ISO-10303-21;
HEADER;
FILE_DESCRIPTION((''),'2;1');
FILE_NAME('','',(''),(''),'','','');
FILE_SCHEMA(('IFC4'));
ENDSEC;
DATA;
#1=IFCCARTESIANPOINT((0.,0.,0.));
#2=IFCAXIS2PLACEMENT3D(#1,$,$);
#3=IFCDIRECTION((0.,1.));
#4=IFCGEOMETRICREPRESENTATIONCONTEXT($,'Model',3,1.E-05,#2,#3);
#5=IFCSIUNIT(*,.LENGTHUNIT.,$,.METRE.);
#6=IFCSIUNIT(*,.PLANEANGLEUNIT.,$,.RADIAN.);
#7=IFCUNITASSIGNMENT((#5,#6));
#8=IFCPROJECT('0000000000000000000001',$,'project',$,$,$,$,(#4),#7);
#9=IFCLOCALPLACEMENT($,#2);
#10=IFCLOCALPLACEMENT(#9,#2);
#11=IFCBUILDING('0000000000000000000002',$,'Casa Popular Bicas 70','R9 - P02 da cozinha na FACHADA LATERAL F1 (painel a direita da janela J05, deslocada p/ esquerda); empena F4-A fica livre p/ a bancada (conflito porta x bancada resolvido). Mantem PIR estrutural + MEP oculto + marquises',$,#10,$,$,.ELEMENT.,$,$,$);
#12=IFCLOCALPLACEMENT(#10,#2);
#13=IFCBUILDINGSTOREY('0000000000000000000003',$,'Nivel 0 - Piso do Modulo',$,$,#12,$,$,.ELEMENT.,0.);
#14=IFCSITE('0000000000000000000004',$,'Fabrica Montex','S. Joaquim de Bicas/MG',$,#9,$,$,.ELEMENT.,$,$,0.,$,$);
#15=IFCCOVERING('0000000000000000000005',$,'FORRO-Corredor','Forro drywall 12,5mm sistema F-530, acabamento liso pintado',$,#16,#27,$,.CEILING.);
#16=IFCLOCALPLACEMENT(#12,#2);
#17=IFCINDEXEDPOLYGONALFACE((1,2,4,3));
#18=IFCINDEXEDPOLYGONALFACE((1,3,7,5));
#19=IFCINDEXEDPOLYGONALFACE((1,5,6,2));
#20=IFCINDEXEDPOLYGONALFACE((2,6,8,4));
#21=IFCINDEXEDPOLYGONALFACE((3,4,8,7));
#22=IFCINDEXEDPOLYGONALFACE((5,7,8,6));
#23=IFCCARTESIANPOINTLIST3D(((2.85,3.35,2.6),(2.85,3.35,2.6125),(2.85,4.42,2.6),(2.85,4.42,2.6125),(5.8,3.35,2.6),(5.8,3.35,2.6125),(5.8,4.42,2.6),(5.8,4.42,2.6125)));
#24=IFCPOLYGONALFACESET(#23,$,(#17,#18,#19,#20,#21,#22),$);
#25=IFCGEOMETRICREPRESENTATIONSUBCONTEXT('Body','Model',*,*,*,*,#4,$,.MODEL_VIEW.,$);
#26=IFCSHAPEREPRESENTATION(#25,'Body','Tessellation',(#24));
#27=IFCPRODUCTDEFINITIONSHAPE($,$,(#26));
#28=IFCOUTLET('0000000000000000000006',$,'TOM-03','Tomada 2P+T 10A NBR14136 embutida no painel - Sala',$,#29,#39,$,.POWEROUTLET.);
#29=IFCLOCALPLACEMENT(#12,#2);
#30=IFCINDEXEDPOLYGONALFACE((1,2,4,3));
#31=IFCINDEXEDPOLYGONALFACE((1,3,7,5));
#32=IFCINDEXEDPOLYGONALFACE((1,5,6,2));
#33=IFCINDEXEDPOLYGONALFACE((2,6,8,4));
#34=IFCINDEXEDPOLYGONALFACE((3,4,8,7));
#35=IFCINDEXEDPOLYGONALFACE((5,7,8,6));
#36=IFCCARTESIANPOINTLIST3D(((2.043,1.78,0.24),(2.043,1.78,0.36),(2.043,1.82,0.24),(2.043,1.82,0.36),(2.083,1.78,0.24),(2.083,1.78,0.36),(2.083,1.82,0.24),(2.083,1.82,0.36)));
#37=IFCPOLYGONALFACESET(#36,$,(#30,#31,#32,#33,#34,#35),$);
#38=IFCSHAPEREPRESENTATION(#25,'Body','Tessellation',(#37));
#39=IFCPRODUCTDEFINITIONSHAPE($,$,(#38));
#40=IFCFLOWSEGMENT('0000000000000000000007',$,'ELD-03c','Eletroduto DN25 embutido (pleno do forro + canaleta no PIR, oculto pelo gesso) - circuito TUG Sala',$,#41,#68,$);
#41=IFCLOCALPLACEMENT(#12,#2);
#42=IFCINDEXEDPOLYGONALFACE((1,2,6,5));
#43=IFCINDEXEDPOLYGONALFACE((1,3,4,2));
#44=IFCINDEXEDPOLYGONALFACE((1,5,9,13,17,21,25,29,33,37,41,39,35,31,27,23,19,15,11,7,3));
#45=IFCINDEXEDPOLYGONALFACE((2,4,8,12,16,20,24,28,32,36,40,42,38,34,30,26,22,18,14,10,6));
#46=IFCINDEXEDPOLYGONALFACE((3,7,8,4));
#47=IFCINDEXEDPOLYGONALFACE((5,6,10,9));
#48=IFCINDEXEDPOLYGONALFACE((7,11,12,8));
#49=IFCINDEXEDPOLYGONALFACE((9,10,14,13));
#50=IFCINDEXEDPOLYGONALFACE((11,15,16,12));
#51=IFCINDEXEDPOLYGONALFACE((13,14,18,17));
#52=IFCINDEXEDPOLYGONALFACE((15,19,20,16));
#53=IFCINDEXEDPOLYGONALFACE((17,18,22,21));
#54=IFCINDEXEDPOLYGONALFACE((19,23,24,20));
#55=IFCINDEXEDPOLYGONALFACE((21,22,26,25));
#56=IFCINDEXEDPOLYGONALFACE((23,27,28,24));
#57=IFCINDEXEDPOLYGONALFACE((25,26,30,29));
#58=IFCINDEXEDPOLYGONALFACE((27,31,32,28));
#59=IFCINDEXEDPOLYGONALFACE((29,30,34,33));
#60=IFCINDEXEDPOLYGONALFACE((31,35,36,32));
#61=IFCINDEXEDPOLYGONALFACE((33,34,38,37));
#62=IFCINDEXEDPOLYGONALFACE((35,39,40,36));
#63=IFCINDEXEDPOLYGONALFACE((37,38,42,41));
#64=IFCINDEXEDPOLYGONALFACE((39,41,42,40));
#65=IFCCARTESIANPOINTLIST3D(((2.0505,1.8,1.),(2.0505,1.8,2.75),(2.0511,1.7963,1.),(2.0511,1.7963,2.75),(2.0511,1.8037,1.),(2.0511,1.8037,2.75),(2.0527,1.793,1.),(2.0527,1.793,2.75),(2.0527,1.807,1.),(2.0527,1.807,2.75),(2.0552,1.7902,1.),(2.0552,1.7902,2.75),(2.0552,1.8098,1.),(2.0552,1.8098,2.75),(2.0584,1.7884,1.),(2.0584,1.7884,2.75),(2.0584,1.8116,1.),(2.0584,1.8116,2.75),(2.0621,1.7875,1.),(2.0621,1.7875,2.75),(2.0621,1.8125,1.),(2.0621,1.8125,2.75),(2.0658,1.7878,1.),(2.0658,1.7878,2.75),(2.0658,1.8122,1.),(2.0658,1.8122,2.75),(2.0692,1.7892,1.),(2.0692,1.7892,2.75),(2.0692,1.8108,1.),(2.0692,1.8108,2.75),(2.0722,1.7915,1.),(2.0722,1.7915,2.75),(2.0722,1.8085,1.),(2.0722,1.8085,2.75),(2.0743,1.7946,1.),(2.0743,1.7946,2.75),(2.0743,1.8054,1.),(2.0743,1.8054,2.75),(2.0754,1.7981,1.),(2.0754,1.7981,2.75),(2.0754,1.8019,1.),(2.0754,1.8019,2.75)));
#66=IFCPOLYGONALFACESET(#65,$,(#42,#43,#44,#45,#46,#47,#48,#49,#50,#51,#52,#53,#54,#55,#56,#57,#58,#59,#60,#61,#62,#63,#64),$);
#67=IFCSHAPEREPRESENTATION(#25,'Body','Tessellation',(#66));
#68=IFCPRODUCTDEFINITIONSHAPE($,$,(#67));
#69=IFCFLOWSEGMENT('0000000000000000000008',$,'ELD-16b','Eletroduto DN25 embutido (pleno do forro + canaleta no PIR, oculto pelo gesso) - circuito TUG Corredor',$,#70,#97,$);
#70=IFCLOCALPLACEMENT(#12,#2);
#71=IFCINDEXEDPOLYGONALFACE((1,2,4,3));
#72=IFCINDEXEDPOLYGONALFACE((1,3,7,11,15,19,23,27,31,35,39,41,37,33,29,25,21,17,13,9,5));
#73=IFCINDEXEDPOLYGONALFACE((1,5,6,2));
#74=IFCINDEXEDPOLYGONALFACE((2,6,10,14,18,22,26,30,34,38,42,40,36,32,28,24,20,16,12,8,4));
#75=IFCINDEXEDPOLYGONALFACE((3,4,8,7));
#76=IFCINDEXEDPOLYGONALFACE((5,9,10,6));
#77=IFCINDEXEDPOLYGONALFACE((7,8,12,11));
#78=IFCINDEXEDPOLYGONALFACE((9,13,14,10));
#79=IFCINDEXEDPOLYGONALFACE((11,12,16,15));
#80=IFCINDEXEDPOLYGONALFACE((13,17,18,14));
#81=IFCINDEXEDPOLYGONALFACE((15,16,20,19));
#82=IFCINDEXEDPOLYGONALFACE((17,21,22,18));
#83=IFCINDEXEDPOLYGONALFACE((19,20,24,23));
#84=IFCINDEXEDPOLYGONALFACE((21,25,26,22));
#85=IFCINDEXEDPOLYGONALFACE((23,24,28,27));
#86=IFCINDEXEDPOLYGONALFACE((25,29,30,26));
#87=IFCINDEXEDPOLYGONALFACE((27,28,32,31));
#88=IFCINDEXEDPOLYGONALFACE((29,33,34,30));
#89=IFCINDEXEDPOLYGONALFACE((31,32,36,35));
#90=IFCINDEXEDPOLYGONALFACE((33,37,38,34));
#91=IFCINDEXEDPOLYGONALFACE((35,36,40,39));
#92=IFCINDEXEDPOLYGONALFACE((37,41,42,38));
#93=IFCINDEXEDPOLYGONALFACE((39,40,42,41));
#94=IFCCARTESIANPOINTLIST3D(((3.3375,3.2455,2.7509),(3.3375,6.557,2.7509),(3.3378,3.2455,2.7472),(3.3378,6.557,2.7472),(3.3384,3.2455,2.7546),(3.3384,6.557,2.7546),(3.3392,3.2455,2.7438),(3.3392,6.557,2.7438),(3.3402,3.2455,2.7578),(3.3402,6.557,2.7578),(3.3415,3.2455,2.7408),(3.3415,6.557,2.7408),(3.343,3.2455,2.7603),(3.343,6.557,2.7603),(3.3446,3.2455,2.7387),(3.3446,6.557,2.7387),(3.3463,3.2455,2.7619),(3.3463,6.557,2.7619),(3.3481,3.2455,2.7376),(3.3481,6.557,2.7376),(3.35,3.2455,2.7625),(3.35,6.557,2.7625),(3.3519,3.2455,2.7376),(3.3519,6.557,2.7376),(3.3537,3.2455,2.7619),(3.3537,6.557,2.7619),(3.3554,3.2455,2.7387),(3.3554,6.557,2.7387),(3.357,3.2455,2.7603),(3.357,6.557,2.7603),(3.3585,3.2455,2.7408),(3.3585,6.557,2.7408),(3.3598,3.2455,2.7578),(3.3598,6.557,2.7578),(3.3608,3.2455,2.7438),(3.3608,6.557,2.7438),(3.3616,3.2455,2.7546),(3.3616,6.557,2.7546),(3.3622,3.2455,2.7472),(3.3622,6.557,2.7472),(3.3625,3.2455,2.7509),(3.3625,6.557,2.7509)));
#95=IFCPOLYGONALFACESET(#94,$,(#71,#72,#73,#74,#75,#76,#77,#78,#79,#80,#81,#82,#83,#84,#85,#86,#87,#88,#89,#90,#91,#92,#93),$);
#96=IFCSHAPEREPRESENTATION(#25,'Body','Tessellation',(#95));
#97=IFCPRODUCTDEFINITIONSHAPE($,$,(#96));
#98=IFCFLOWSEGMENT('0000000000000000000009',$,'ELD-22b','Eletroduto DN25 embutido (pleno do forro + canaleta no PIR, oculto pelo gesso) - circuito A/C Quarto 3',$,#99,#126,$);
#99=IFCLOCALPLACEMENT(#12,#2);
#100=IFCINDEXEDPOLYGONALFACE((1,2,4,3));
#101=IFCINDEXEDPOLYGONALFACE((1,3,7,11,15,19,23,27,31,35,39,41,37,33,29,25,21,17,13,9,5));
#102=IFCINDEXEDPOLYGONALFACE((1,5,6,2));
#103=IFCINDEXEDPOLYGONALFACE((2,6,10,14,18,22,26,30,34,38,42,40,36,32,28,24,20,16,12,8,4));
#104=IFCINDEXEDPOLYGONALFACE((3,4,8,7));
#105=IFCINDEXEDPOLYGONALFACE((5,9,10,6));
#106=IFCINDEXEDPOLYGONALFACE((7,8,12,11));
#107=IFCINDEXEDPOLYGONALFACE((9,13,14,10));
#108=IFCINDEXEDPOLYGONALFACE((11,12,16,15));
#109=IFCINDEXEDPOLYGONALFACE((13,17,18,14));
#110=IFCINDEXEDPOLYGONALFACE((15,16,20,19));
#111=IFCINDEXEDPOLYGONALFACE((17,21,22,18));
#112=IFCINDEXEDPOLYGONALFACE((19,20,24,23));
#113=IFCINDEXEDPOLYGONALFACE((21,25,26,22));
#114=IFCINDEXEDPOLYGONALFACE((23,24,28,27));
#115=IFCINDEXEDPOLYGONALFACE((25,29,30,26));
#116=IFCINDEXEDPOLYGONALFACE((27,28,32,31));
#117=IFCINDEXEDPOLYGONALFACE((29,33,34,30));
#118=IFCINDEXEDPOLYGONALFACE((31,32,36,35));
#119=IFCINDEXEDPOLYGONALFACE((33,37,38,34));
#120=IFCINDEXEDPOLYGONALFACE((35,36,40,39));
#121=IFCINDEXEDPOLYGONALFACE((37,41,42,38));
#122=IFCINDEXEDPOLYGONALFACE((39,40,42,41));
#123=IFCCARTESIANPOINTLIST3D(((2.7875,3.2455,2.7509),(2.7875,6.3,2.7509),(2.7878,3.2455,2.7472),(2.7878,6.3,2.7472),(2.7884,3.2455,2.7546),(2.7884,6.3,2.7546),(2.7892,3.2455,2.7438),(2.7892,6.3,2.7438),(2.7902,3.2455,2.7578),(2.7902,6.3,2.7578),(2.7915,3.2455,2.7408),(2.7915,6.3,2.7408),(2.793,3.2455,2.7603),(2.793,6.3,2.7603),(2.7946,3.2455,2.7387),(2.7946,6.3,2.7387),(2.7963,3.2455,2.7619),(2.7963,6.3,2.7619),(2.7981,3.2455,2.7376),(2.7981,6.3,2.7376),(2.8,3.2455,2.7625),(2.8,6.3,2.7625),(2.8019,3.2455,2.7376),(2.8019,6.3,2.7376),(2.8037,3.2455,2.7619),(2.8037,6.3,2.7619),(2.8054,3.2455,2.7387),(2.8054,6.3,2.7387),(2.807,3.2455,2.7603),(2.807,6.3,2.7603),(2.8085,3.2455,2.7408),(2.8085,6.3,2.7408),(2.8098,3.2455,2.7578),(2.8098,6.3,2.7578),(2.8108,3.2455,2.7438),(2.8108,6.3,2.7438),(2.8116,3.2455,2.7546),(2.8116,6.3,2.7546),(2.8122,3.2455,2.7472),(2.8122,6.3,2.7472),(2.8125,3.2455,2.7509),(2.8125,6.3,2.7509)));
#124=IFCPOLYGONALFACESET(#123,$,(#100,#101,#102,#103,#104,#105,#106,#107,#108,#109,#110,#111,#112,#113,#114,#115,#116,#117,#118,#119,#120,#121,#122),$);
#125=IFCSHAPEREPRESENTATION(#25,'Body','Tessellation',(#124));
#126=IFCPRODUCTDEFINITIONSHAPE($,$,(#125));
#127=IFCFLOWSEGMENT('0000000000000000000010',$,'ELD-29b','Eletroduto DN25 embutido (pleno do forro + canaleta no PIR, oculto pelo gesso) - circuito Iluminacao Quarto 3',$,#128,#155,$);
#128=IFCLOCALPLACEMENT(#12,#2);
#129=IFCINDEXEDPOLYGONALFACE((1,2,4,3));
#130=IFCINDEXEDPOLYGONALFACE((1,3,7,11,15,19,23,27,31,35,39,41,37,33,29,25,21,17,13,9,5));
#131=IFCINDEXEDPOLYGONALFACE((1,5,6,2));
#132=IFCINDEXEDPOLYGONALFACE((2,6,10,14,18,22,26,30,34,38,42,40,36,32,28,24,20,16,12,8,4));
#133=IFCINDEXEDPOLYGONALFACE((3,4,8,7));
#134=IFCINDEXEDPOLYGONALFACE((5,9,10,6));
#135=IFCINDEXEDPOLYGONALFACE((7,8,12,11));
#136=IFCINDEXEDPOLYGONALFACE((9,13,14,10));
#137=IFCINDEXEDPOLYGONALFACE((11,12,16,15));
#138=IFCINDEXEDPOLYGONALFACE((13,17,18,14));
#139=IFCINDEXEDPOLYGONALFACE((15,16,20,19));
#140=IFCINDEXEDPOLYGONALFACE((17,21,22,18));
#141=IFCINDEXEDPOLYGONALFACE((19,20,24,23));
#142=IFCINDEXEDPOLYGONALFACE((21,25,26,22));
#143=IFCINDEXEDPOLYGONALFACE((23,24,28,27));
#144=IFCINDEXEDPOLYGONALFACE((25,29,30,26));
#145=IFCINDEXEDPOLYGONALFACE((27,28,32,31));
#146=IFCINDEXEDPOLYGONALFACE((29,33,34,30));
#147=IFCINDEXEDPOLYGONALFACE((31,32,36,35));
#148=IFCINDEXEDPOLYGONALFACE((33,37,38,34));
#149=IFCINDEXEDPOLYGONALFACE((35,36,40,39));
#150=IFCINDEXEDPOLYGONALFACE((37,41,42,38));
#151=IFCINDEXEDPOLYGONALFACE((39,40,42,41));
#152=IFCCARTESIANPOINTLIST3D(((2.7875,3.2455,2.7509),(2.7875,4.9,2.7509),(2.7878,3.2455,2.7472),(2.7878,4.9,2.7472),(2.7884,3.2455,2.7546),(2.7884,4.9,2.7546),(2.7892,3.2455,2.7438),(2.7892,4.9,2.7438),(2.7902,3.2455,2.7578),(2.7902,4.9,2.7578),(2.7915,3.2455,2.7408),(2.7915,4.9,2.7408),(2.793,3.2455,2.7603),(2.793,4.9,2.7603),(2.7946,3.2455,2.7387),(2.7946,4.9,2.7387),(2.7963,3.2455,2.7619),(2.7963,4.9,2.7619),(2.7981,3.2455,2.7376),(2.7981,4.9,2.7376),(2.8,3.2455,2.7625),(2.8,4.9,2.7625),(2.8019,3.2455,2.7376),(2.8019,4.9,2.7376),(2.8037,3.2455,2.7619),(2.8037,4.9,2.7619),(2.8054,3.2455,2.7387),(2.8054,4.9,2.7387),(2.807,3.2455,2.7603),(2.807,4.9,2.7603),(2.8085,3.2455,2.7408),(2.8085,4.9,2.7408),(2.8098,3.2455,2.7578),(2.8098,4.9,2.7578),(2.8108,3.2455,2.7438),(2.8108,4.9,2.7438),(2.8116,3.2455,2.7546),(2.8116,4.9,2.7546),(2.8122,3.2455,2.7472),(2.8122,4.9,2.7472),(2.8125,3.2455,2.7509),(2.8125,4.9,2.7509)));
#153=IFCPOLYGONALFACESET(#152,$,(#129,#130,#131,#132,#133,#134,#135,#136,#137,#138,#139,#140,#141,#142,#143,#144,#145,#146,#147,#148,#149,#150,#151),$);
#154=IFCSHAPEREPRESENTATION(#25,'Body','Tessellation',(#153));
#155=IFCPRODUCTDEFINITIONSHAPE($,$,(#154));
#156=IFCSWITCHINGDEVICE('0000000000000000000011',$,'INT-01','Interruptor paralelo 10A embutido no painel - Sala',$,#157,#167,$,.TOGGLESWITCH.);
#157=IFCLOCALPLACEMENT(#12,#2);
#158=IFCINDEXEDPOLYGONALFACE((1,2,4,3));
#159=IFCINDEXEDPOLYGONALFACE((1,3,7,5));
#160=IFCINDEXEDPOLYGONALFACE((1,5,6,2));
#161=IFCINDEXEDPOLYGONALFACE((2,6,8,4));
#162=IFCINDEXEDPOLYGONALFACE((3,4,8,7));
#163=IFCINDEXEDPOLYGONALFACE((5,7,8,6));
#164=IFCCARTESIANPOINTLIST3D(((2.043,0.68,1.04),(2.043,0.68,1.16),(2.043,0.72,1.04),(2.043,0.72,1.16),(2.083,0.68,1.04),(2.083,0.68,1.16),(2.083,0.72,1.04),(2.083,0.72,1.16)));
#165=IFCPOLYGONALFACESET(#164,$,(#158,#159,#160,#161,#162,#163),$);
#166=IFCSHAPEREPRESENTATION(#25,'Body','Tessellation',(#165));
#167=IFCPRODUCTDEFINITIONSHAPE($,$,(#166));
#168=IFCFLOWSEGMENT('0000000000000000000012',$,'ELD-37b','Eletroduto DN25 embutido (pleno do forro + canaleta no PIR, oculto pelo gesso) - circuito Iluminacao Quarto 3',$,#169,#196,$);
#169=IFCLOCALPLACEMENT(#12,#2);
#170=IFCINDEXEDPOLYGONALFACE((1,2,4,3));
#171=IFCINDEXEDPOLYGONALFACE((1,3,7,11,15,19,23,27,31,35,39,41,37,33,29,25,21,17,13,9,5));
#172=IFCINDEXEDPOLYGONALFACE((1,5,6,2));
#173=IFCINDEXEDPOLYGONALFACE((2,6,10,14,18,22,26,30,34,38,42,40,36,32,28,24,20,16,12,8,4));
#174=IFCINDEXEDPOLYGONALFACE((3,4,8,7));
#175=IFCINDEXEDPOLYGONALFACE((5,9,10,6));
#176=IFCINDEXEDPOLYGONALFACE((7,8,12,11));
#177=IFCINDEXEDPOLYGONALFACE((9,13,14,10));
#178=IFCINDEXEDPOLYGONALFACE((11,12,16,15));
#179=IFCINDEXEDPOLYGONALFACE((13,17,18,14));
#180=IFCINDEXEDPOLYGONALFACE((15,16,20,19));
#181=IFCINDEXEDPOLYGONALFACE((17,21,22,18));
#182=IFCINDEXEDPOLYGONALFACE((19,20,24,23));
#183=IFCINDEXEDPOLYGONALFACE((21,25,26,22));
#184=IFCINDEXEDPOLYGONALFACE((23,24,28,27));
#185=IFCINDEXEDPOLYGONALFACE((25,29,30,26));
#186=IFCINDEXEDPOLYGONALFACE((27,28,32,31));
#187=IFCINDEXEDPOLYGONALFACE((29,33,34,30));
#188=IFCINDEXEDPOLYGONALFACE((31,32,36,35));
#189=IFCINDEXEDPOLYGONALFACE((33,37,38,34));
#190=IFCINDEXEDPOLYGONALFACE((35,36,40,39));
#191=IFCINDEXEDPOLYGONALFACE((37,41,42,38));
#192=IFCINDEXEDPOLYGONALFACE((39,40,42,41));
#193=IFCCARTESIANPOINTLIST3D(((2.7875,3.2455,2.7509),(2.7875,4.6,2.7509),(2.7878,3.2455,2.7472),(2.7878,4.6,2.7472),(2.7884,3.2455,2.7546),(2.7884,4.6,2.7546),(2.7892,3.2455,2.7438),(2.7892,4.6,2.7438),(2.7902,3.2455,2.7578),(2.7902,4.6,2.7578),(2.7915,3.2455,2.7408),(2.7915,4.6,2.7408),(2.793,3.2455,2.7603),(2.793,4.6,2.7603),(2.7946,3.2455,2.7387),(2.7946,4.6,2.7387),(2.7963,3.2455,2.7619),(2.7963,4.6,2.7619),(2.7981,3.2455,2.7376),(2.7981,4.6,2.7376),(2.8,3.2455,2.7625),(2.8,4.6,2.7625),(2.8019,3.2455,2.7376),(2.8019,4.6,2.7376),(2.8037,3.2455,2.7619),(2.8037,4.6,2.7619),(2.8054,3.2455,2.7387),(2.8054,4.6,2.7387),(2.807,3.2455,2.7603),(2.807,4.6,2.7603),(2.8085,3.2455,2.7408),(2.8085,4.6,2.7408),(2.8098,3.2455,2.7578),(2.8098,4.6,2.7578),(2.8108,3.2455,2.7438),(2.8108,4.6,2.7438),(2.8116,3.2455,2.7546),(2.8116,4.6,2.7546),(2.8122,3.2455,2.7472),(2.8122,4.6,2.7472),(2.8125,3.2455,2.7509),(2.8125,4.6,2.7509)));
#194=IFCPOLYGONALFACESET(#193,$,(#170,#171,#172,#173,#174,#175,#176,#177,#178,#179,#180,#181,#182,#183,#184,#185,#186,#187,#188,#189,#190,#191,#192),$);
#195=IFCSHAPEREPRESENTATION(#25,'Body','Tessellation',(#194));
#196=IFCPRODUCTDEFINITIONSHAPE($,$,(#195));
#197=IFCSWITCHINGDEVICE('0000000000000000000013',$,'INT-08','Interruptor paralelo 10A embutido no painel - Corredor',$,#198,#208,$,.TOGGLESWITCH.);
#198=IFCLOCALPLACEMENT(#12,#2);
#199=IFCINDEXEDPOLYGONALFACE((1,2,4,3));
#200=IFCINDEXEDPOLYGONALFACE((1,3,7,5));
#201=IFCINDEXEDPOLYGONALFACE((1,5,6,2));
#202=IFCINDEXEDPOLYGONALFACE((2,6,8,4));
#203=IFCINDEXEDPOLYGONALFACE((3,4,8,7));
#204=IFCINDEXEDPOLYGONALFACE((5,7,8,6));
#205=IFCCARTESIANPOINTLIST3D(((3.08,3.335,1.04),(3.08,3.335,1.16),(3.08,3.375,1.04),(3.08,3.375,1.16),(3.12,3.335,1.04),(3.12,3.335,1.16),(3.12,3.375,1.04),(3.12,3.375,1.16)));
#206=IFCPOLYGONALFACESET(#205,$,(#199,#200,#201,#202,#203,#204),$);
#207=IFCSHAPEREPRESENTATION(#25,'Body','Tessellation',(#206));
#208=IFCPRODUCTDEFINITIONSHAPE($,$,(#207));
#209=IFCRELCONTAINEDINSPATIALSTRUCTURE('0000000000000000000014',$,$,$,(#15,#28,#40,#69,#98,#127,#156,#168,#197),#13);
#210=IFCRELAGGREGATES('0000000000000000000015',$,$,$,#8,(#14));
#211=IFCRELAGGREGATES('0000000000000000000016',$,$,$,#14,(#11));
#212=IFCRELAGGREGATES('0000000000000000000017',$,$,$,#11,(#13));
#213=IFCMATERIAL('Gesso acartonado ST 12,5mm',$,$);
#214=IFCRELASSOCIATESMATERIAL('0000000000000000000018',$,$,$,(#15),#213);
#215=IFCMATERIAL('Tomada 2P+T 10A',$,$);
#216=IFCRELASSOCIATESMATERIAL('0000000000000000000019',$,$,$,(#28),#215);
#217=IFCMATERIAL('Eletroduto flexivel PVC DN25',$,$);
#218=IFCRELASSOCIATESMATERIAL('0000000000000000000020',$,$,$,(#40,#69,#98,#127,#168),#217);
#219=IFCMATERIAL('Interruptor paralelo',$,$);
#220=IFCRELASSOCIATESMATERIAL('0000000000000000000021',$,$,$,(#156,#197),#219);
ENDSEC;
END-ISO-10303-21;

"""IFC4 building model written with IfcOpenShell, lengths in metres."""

from ifc_helpers import new_model, si_unit, direction, frame, frame_2d, origin, origin_2d, place, context, subcontext, project, spatial, rectangle, circle, extrude, material, element, save


model = new_model("IFC4")

# Units and contexts
model_context = context("Model", 3, precision=1e-05, world=origin(), true_north=direction((0.0, 1.0)))
body_context = subcontext(model_context, "Body", "Model", "MODEL_VIEW")
ifc_project = project(units=[si_unit("LENGTHUNIT", "METRE"), si_unit("PLANEANGLEUNIT", "RADIAN")], contexts=[model_context])

# Site, building, storey
site_placement = place(None, origin())
site = spatial("IfcSite", under=ifc_project, at=site_placement, Name="Fabrica Montex", Description="S. Joaquim de Bicas/MG", CompositionType="ELEMENT", RefElevation=0.0)
building_placement = place(site_placement, origin())
building = spatial("IfcBuilding", under=site, at=building_placement, Name="Casa Popular Bicas 70", Description="R9 - P02 da cozinha na FACHADA LATERAL F1 (painel a direita da janela J05, deslocada p/ esquerda); empena F4-A fica livre p/ a bancada (conflito porta x bancada resolvido). Mantem PIR estrutural + MEP oculto + marquises", CompositionType="ELEMENT")
storey_placement = place(building_placement, origin())
storey = spatial("IfcBuildingStorey", under=building, at=storey_placement, Name="Nivel 0 - Piso do Modulo", CompositionType="ELEMENT", Elevation=0.0)

# Covering
ifc_material_1 = material(Name="Gesso acartonado ST 12,5mm")
covering_1_placement = place(storey_placement, frame((2.85, 3.35, 2.6)))
element("IfcCovering", 1, at=covering_1_placement, inside=storey, material=ifc_material_1, Name="FORRO-Corredor", Description="Forro drywall 12,5mm sistema F-530, acabamento liso pintado", PredefinedType="CEILING", context=body_context, shape_type="SweptSolid", body=[
    extrude(rectangle(XDim=2.95, YDim=1.07, at=frame_2d((1.475, 0.535))), origin(), (0.0, 0.0, 1.0), 0.0125),
])

# Outlet
ifc_material_2 = material(Name="Tomada 2P+T 10A")
outlet_placement = place(None, frame((2.083, 1.82, 0.24), z_axis=(0.0, 0.0, 1.0), x_axis=(-1.0, 0.0, 0.0)))
element("IfcOutlet", 2, at=outlet_placement, inside=storey, material=ifc_material_2, Name="TOM-03", Description="Tomada 2P+T 10A NBR14136 embutida no painel - Sala", PredefinedType="POWEROUTLET", context=body_context, shape_type="SweptSolid", body=[
    extrude(rectangle(XDim=0.04, YDim=0.04, at=frame_2d((0.02, 0.02))), origin(), (0.0, 0.0, 1.0), 0.12),
])

# Flow segments
ifc_material_3 = material(Name="Eletroduto flexivel PVC DN25")
flow_segment_1_placement = place(None, frame((2.063, 1.8, 2.75), z_axis=(0.0, 0.0, -1.0), x_axis=(-1.0, 0.0, 0.0)))
element("IfcFlowSegment", 3, at=flow_segment_1_placement, inside=storey, material=ifc_material_3, Name="ELD-03c", Description="Eletroduto DN25 embutido (pleno do forro + canaleta no PIR, oculto pelo gesso) - circuito TUG Sala", context=body_context, shape_type="SweptSolid", body=[
    extrude(circle(Radius=0.0125, at=origin_2d()), origin(), (0.0, 0.0, 1.0), 1.75),
])
flow_segment_2_placement = place(storey_placement, frame((3.35, 3.2455, 2.75), z_axis=(0.0, 1.0, 0.0), x_axis=(0.0, 0.0, 1.0)))
element("IfcFlowSegment", 4, at=flow_segment_2_placement, inside=storey, material=ifc_material_3, Name="ELD-16b", Description="Eletroduto DN25 embutido (pleno do forro + canaleta no PIR, oculto pelo gesso) - circuito TUG Corredor", context=body_context, shape_type="SweptSolid", body=[
    extrude(circle(Radius=0.0125, at=origin_2d()), origin(), (0.0, 0.0, 1.0), 3.3115),
])
flow_segment_3_placement = place(storey_placement, frame((2.8, 3.2455, 2.75), z_axis=(0.0, 1.0, 0.0), x_axis=(0.0, 0.0, 1.0)))
element("IfcFlowSegment", 5, at=flow_segment_3_placement, inside=storey, material=ifc_material_3, Name="ELD-22b", Description="Eletroduto DN25 embutido (pleno do forro + canaleta no PIR, oculto pelo gesso) - circuito A/C Quarto 3", context=body_context, shape_type="SweptSolid", body=[
    extrude(circle(Radius=0.0125, at=origin_2d()), origin(), (0.0, 0.0, 1.0), 3.0545),
])
flow_segment_4_placement = place(storey_placement, frame((2.8, 3.2455, 2.75), z_axis=(0.0, 1.0, 0.0), x_axis=(0.0, 0.0, 1.0)))
element("IfcFlowSegment", 6, at=flow_segment_4_placement, inside=storey, material=ifc_material_3, Name="ELD-29b", Description="Eletroduto DN25 embutido (pleno do forro + canaleta no PIR, oculto pelo gesso) - circuito Iluminacao Quarto 3", context=body_context, shape_type="SweptSolid", body=[
    extrude(circle(Radius=0.0125, at=origin_2d()), origin(), (0.0, 0.0, 1.0), 1.6545),
])

# Switching device
ifc_material_4 = material(Name="Interruptor paralelo")
switching_device_1_placement = place(None, frame((2.083, 0.72, 1.04), z_axis=(0.0, 0.0, 1.0), x_axis=(-1.0, 0.0, 0.0)))
element("IfcSwitchingDevice", 7, at=switching_device_1_placement, inside=storey, material=ifc_material_4, Name="INT-01", Description="Interruptor paralelo 10A embutido no painel - Sala", PredefinedType="TOGGLESWITCH", context=body_context, shape_type="SweptSolid", body=[
    extrude(rectangle(XDim=0.04, YDim=0.04, at=frame_2d((0.02, 0.02))), origin(), (0.0, 0.0, 1.0), 0.12),
])

# Flow segment
flow_segment_5_placement = place(storey_placement, frame((2.8, 3.2455, 2.75), z_axis=(0.0, 1.0, 0.0), x_axis=(0.0, 0.0, 1.0)))
element("IfcFlowSegment", 8, at=flow_segment_5_placement, inside=storey, material=ifc_material_3, Name="ELD-37b", Description="Eletroduto DN25 embutido (pleno do forro + canaleta no PIR, oculto pelo gesso) - circuito Iluminacao Quarto 3", context=body_context, shape_type="SweptSolid", body=[
    extrude(circle(Radius=0.0125, at=origin_2d()), origin(), (0.0, 0.0, 1.0), 1.3545),
])

# Switching device
switching_device_2_placement = place(storey_placement, frame((3.08, 3.335, 1.04)))
element("IfcSwitchingDevice", 9, at=switching_device_2_placement, inside=storey, material=ifc_material_4, Name="INT-08", Description="Interruptor paralelo 10A embutido no painel - Corredor", PredefinedType="TOGGLESWITCH", context=body_context, shape_type="SweptSolid", body=[
    extrude(rectangle(XDim=0.04, YDim=0.04, at=frame_2d((0.02, 0.02))), origin(), (0.0, 0.0, 1.0), 0.12),
])

save(model, "model.ifc")
